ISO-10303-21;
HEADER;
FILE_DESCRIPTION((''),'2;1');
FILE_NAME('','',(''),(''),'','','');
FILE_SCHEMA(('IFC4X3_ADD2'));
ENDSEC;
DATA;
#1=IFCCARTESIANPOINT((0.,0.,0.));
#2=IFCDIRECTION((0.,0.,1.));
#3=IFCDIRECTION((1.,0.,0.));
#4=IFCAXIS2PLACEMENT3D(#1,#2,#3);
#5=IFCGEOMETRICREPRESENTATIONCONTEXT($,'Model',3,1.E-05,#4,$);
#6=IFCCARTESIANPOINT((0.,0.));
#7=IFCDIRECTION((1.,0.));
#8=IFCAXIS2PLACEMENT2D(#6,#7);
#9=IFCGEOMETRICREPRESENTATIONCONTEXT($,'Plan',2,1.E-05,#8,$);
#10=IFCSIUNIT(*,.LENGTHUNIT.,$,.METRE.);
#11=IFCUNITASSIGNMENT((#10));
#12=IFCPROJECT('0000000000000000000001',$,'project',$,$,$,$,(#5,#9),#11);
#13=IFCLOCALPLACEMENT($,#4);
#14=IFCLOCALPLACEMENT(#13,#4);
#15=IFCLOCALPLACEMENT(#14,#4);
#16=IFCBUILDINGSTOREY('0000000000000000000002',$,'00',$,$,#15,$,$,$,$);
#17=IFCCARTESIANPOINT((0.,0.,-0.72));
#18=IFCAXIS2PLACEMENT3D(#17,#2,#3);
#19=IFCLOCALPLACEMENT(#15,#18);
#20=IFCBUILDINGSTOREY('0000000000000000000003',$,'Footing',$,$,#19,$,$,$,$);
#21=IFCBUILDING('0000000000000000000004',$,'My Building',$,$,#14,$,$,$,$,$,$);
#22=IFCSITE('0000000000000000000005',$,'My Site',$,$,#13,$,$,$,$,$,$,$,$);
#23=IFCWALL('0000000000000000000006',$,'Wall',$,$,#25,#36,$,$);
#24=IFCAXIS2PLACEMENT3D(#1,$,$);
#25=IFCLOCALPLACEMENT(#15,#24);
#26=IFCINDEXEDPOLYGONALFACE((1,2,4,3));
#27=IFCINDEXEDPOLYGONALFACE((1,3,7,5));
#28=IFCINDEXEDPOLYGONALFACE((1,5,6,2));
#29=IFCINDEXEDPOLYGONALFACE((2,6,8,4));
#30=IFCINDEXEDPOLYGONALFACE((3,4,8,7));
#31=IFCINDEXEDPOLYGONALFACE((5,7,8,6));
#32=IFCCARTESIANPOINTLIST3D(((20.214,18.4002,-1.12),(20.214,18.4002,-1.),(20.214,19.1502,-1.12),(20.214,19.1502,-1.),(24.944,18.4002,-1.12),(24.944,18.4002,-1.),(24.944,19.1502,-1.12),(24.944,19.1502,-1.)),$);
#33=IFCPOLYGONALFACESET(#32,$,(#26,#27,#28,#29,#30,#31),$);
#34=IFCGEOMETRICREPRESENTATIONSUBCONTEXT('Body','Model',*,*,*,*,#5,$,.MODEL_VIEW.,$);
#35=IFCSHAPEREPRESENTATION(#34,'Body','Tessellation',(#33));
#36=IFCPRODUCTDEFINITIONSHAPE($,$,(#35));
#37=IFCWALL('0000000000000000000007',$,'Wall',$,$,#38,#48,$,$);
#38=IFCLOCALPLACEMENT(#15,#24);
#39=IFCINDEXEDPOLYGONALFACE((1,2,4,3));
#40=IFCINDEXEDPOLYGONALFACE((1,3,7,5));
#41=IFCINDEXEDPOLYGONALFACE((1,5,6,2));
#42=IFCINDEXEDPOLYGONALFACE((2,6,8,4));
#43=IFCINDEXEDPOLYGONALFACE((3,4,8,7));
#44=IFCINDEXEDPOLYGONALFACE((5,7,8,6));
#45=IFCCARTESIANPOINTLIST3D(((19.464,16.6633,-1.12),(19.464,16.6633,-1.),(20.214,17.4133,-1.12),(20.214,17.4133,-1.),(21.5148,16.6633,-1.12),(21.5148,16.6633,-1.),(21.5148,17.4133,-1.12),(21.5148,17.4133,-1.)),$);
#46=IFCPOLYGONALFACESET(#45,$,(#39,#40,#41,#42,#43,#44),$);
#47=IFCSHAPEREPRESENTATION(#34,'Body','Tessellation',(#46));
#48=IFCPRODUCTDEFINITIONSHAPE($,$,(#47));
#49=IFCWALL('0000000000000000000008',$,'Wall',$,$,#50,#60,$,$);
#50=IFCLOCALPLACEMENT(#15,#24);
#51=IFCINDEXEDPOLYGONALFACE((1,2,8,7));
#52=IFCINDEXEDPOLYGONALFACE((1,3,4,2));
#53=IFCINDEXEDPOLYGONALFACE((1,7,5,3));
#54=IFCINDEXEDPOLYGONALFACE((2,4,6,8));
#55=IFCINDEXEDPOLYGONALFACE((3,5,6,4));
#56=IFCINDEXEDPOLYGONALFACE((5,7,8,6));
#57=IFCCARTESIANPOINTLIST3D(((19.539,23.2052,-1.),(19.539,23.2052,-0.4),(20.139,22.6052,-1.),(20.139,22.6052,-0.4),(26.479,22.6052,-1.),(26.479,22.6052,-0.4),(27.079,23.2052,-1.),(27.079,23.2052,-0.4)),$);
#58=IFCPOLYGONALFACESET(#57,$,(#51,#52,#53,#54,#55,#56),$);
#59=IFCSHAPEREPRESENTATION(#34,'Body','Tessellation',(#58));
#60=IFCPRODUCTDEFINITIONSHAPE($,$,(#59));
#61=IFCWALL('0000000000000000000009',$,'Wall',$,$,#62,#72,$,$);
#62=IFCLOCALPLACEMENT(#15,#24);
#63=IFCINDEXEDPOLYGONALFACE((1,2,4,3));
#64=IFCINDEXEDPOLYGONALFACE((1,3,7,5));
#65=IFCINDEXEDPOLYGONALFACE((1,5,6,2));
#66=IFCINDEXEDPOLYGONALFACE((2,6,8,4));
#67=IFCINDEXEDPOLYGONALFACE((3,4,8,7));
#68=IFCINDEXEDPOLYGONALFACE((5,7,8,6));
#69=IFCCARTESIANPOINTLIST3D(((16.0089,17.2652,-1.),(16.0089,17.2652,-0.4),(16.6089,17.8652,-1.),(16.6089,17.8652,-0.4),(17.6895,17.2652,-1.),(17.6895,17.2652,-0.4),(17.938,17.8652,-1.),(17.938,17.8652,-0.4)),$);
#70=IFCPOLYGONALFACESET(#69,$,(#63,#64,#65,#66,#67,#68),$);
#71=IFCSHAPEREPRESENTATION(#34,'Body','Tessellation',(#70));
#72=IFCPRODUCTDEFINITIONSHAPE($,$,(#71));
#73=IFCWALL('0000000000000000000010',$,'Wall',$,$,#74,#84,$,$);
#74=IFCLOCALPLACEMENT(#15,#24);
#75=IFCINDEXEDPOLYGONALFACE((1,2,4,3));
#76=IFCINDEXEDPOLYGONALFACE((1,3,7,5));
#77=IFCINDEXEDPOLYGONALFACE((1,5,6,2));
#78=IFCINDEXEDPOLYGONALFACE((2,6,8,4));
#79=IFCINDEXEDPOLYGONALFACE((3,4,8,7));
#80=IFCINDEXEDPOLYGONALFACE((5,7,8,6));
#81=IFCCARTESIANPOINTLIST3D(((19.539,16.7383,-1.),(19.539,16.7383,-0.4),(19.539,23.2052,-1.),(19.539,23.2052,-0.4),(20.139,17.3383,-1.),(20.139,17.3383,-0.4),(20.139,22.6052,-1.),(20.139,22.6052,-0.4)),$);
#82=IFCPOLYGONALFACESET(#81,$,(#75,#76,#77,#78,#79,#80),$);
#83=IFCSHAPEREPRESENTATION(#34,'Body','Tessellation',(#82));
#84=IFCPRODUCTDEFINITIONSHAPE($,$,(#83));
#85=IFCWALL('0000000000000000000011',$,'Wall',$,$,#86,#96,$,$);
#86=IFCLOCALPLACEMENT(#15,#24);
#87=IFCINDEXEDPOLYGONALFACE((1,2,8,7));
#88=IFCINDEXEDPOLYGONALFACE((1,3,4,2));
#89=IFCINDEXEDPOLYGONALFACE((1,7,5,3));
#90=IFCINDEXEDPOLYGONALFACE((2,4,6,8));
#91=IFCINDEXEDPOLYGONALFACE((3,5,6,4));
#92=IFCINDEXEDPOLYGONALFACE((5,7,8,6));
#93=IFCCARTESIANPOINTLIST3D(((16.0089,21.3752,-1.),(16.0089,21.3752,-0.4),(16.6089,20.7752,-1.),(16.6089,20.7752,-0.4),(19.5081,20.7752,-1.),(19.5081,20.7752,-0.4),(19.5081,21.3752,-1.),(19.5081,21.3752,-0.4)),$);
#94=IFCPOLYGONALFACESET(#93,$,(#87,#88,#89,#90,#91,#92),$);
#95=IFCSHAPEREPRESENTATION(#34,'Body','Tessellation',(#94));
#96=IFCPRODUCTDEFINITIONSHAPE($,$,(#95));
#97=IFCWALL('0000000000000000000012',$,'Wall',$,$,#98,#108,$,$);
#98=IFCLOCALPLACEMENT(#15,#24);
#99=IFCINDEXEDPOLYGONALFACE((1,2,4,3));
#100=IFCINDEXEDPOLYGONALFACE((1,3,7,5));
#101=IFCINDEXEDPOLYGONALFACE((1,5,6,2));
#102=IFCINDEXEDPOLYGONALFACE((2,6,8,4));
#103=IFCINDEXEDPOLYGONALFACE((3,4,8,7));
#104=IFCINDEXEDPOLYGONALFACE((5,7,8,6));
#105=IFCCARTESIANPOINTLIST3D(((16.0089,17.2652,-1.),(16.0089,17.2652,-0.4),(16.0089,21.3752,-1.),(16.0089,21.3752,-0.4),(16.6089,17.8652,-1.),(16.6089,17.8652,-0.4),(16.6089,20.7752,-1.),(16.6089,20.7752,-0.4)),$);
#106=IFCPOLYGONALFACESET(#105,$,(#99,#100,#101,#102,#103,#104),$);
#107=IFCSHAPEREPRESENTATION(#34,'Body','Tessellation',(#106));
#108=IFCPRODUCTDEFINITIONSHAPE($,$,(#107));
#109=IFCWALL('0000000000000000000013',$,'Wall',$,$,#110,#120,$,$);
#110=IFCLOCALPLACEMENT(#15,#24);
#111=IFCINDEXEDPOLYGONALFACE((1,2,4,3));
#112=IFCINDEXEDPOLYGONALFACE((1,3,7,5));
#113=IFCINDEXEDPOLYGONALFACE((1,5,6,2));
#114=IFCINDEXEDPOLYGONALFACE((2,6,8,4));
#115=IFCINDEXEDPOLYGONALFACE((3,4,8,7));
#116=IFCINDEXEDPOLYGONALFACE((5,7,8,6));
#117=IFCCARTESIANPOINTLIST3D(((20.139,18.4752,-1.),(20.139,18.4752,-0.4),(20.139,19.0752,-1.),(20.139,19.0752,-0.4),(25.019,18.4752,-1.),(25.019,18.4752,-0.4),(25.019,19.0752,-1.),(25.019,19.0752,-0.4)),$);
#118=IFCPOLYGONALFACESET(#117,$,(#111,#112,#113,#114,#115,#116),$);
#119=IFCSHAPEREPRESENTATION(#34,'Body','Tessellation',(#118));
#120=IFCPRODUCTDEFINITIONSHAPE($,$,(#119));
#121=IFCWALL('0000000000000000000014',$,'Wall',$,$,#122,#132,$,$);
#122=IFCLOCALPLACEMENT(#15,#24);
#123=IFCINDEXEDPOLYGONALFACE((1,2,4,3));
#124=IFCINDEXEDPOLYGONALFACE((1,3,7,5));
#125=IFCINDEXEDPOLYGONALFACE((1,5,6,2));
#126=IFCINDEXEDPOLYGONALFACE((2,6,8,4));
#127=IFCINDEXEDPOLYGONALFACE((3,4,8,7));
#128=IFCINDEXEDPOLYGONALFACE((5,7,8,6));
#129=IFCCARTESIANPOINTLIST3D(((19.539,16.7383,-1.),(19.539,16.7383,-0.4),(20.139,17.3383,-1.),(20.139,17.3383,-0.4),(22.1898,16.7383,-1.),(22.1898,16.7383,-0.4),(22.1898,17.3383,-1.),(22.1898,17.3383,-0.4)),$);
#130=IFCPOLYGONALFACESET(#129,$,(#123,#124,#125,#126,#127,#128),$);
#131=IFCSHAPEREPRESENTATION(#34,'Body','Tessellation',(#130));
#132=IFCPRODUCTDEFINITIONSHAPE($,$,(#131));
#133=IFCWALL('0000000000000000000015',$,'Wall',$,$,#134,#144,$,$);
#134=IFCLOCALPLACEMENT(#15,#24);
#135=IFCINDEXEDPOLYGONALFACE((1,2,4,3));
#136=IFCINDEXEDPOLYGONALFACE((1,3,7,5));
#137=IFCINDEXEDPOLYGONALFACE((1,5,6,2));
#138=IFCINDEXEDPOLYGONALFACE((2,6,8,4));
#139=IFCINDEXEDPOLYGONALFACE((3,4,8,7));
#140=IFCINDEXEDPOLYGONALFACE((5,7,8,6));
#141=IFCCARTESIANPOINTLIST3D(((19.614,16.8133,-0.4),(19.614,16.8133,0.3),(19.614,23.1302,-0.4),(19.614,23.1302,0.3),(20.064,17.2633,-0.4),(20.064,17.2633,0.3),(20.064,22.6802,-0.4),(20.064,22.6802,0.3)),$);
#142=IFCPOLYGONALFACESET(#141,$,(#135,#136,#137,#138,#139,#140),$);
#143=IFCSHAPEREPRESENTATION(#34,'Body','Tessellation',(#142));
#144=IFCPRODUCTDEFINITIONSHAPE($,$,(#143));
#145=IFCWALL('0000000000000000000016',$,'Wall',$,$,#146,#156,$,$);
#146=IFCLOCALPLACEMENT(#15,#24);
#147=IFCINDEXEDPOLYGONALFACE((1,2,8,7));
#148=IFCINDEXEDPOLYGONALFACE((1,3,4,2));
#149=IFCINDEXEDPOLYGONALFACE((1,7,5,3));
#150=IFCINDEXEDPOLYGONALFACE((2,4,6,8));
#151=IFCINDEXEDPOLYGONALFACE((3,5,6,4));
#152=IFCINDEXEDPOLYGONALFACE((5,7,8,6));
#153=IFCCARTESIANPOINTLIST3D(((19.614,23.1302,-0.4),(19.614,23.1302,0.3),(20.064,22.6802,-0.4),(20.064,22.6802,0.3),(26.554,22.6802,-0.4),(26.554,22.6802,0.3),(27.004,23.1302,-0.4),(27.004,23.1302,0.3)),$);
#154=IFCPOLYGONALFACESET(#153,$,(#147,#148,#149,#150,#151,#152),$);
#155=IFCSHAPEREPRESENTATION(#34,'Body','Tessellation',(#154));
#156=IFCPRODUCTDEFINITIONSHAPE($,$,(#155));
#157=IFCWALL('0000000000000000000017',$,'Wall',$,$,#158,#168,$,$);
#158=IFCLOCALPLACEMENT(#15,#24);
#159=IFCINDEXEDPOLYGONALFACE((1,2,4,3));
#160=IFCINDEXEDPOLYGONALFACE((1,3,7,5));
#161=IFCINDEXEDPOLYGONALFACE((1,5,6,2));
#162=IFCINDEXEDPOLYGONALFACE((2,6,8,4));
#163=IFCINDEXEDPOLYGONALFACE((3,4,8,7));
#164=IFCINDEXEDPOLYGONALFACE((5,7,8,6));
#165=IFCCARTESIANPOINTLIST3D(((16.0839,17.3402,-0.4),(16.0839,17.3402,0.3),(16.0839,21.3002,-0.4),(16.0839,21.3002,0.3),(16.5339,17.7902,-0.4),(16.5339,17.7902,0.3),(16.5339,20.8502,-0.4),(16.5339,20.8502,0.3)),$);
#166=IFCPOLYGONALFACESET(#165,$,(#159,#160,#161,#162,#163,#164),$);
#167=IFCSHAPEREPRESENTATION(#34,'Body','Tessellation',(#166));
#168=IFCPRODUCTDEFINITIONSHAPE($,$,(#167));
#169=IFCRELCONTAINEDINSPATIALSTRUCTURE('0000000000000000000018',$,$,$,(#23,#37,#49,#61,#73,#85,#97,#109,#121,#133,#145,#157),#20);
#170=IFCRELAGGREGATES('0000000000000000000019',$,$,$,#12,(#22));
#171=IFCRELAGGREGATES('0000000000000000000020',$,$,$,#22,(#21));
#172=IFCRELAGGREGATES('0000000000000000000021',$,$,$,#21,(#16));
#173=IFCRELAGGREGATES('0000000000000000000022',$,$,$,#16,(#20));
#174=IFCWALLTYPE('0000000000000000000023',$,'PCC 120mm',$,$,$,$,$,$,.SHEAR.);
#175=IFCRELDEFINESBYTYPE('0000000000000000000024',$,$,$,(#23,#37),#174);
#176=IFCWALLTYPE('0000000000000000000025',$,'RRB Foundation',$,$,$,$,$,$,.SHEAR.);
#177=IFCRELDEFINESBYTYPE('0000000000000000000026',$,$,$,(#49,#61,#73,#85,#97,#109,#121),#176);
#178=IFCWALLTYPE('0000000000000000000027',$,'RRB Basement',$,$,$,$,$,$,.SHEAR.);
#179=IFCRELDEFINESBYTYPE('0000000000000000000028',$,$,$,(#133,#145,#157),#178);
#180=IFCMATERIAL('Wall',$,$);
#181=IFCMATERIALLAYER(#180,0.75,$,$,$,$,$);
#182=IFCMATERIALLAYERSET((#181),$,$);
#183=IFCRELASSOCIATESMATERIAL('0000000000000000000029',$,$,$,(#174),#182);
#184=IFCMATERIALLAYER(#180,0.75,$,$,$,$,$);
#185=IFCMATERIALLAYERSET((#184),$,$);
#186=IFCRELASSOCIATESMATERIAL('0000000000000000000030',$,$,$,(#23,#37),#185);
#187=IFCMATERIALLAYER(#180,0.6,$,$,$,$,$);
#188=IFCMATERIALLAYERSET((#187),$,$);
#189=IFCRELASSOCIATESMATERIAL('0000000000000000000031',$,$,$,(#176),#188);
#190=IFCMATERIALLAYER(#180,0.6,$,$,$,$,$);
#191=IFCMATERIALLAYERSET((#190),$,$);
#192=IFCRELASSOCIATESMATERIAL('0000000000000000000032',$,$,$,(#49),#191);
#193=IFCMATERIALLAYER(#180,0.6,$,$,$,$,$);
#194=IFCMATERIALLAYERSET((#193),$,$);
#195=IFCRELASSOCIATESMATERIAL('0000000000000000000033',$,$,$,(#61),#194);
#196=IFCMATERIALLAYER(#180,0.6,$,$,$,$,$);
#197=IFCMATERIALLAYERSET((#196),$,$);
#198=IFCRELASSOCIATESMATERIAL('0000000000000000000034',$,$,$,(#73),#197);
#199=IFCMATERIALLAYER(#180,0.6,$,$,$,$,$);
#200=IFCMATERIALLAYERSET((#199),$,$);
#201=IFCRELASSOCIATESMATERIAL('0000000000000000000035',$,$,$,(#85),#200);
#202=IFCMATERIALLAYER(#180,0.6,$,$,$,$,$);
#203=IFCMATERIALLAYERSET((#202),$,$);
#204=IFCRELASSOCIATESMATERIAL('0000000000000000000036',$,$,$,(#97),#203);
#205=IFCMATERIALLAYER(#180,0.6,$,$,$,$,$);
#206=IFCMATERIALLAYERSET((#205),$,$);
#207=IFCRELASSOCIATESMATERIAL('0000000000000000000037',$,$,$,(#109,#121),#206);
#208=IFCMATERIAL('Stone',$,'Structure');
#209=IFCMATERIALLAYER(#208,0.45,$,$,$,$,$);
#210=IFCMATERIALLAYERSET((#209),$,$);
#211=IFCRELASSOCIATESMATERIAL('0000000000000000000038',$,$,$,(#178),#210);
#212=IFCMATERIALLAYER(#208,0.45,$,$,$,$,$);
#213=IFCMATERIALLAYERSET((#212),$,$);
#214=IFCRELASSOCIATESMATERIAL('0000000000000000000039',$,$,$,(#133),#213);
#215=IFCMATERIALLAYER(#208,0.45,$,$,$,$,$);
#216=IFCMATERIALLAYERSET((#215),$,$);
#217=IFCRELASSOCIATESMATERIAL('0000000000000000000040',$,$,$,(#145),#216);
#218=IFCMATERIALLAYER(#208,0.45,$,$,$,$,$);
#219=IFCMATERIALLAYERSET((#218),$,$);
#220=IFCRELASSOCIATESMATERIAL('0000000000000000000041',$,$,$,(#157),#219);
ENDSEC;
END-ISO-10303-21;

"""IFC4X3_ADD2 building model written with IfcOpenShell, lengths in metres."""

from ifc_helpers import new_model, si_unit, frame, origin_with_axes, origin_2d_with_axis, place, context, subcontext, project, spatial, line, indexed_curve, outline, extrude, material, layer, layer_set, layer_usage, type_object, element, save


model = new_model("IFC4X3_ADD2")

# Units and contexts
model_context = context("Model", 3, precision=1e-05, world=origin_with_axes())
plan_context = context("Plan", 2, precision=1e-05, world=origin_2d_with_axis())
body_context = subcontext(model_context, "Body", "Model", "MODEL_VIEW")
ifc_project = project(units=[si_unit("LENGTHUNIT", "METRE")], contexts=[model_context, plan_context])

# Site, building, storeys
site_placement = place(None, origin_with_axes())
site = spatial("IfcSite", under=ifc_project, at=site_placement, Name="My Site")
building_placement = place(site_placement, origin_with_axes())
building = spatial("IfcBuilding", under=site, at=building_placement, Name="My Building")
storey_1_placement = place(building_placement, origin_with_axes())
storey_1 = spatial("IfcBuildingStorey", under=building, at=storey_1_placement, Name="00")
storey_2_placement = place(storey_1_placement, frame((0.0, 0.0, -0.72), z_axis=(0.0, 0.0, 1.0), x_axis=(1.0, 0.0, 0.0)))
storey_2 = spatial("IfcBuildingStorey", under=storey_1, at=storey_2_placement, Name="Footing")

# Shared definitions
ifc_material_1 = material(Name="Wall")

# Walls
ifc_layer_1 = layer(ifc_material_1, 0.75)
ifc_layer_set_1 = layer_set([ifc_layer_1])
wall_type_1 = type_object("IfcWallType", Name="PCC 120mm", PredefinedType="SHEAR", material=ifc_layer_set_1)
ifc_layer_2 = layer(ifc_material_1, 0.75)
ifc_layer_set_2 = layer_set([ifc_layer_2])
ifc_layer_usage_1 = layer_usage(ifc_layer_set_2, "AXIS2", "POSITIVE", 0.0)
wall_1_placement = place(storey_2_placement, frame((20.214, 18.4002, -0.4), z_axis=(0.0, 0.0, 1.0), x_axis=(1.0, 0.0, 0.0)))
element("IfcWall", 1, at=wall_1_placement, inside=storey_2, type_object=wall_type_1, material=ifc_layer_usage_1, Name="Wall", context=body_context, shape_type="SweptSolid", body=[
    extrude(outline(indexed_curve([(0.0, 0.0), (0.0, 0.75), (4.73, 0.75), (4.73, 0.0)], segments=[line(1, 2, 3, 4, 1)])), origin_with_axes(), (0.0, 0.0, 1.0), 0.12),
])
ifc_layer_usage_2 = layer_usage(ifc_layer_set_2, "AXIS2", "POSITIVE", 0.0)
wall_2_placement = place(storey_2_placement, frame((20.214, 16.6633, -0.4), z_axis=(0.0, 0.0, 1.0), x_axis=(1.0, 0.0, 0.0)))
element("IfcWall", 2, at=wall_2_placement, inside=storey_2, type_object=wall_type_1, material=ifc_layer_usage_2, Name="Wall", context=body_context, shape_type="SweptSolid", body=[
    extrude(outline(indexed_curve([(-0.75, 0.0), (0.0, 0.75), (1.3008, 0.75), (1.3008, 0.0)], segments=[line(1, 2, 3, 4, 1)])), origin_with_axes(), (0.0, 0.0, 1.0), 0.12),
])
ifc_layer_3 = layer(ifc_material_1, 0.6)
ifc_layer_set_3 = layer_set([ifc_layer_3])
ifc_layer_usage_3 = layer_usage(ifc_layer_set_3, "AXIS2", "POSITIVE", 0.0)
ifc_layer_4 = layer(ifc_material_1, 0.6)
ifc_layer_set_4 = layer_set([ifc_layer_4])
wall_type_2 = type_object("IfcWallType", Name="RRB Foundation", PredefinedType="SHEAR", material=ifc_layer_set_4)
wall_3_placement = place(storey_2_placement, frame((20.139, 22.6052, -0.28), z_axis=(0.0, 0.0, 1.0), x_axis=(1.0, 0.0, 0.0)))
element("IfcWall", 3, at=wall_3_placement, inside=storey_2, type_object=wall_type_2, material=ifc_layer_usage_3, Name="Wall", context=body_context, shape_type="SweptSolid", body=[
    extrude(outline(indexed_curve([(0.0, 0.0), (-0.6, 0.6), (6.94, 0.6), (6.34, 0.0)], segments=[line(1, 2, 3, 4, 1)])), origin_with_axes(), (0.0, 0.0, 1.0), 0.6),
])
ifc_layer_5 = layer(ifc_material_1, 0.6)
ifc_layer_set_5 = layer_set([ifc_layer_5])
ifc_layer_usage_4 = layer_usage(ifc_layer_set_5, "AXIS2", "POSITIVE", 0.0)
wall_4_placement = place(storey_2_placement, frame((16.6089, 17.2652, -0.28), z_axis=(0.0, 0.0, 1.0), x_axis=(1.0, 0.0, 0.0)))
element("IfcWall", 4, at=wall_4_placement, inside=storey_2, type_object=wall_type_2, material=ifc_layer_usage_4, Name="Wall", context=body_context, shape_type="SweptSolid", body=[
    extrude(outline(indexed_curve([(-0.6, 0.0), (0.0, 0.6), (1.3291, 0.6), (1.0806, 0.0)], segments=[line(1, 2, 3, 4, 1)])), origin_with_axes(), (0.0, 0.0, 1.0), 0.6),
])
ifc_layer_6 = layer(ifc_material_1, 0.6)
ifc_layer_set_6 = layer_set([ifc_layer_6])
ifc_layer_usage_5 = layer_usage(ifc_layer_set_6, "AXIS2", "POSITIVE", 0.0)
wall_5_placement = place(storey_2_placement, frame((20.139, 16.7383, -0.28), z_axis=(0.0, 0.0, 1.0), x_axis=(0.0, 1.0, 0.0)))
element("IfcWall", 5, at=wall_5_placement, inside=storey_2, type_object=wall_type_2, material=ifc_layer_usage_5, Name="Wall", context=body_context, shape_type="SweptSolid", body=[
    extrude(outline(indexed_curve([(0.6, 0.0), (0.0, 0.6), (6.4669, 0.6), (5.8669, 0.0)], segments=[line(1, 2, 3, 4, 1)])), origin_with_axes(), (0.0, 0.0, 1.0), 0.6),
])
ifc_layer_7 = layer(ifc_material_1, 0.6)
ifc_layer_set_7 = layer_set([ifc_layer_7])
ifc_layer_usage_6 = layer_usage(ifc_layer_set_7, "AXIS2", "POSITIVE", 0.0)
wall_6_placement = place(storey_2_placement, frame((16.6089, 20.7752, -0.28), z_axis=(0.0, 0.0, 1.0), x_axis=(1.0, 0.0, 0.0)))
element("IfcWall", 6, at=wall_6_placement, inside=storey_2, type_object=wall_type_2, material=ifc_layer_usage_6, Name="Wall", context=body_context, shape_type="SweptSolid", body=[
    extrude(outline(indexed_curve([(0.0, 0.0), (-0.6, 0.6), (2.8992, 0.6), (2.8992, 0.0)], segments=[line(1, 2, 3, 4, 1)])), origin_with_axes(), (0.0, 0.0, 1.0), 0.6),
])
ifc_layer_8 = layer(ifc_material_1, 0.6)
ifc_layer_set_8 = layer_set([ifc_layer_8])
ifc_layer_usage_7 = layer_usage(ifc_layer_set_8, "AXIS2", "POSITIVE", 0.0)
wall_7_placement = place(storey_2_placement, frame((16.6089, 17.2652, -0.28), z_axis=(0.0, 0.0, 1.0), x_axis=(0.0, 1.0, 0.0)))
element("IfcWall", 7, at=wall_7_placement, inside=storey_2, type_object=wall_type_2, material=ifc_layer_usage_7, Name="Wall", context=body_context, shape_type="SweptSolid", body=[
    extrude(outline(indexed_curve([(0.6, 0.0), (0.0, 0.6), (4.11, 0.6), (3.51, 0.0)], segments=[line(1, 2, 3, 4, 1)])), origin_with_axes(), (0.0, 0.0, 1.0), 0.6),
])
ifc_layer_9 = layer(ifc_material_1, 0.6)
ifc_layer_set_9 = layer_set([ifc_layer_9])
ifc_layer_usage_8 = layer_usage(ifc_layer_set_9, "AXIS2", "POSITIVE", 0.0)
wall_8_placement = place(storey_2_placement, frame((20.139, 18.4752, -0.28), z_axis=(0.0, 0.0, 1.0), x_axis=(1.0, 0.0, 0.0)))
element("IfcWall", 8, at=wall_8_placement, inside=storey_2, type_object=wall_type_2, material=ifc_layer_usage_8, Name="Wall", context=body_context, shape_type="SweptSolid", body=[
    extrude(outline(indexed_curve([(0.0, 0.0), (0.0, 0.6), (4.88, 0.6), (4.88, 0.0)], segments=[line(1, 2, 3, 4, 1)])), origin_with_axes(), (0.0, 0.0, 1.0), 0.6),
])
ifc_layer_usage_9 = layer_usage(ifc_layer_set_9, "AXIS2", "POSITIVE", 0.0)
wall_9_placement = place(storey_2_placement, frame((20.139, 16.7383, -0.28), z_axis=(0.0, 0.0, 1.0), x_axis=(1.0, 0.0, 0.0)))
element("IfcWall", 9, at=wall_9_placement, inside=storey_2, type_object=wall_type_2, material=ifc_layer_usage_9, Name="Wall", context=body_context, shape_type="SweptSolid", body=[
    extrude(outline(indexed_curve([(-0.6, 0.0), (0.0, 0.6), (2.0508, 0.6), (2.0508, 0.0)], segments=[line(1, 2, 3, 4, 1)])), origin_with_axes(), (0.0, 0.0, 1.0), 0.6),
])
ifc_material_2 = material(Name="Stone", Category="Structure")
ifc_layer_10 = layer(ifc_material_2, 0.45)
ifc_layer_set_10 = layer_set([ifc_layer_10])
ifc_layer_usage_10 = layer_usage(ifc_layer_set_10, "AXIS2", "POSITIVE", 0.0)
ifc_layer_11 = layer(ifc_material_2, 0.45)
ifc_layer_set_11 = layer_set([ifc_layer_11])
wall_type_3 = type_object("IfcWallType", Name="RRB Basement", PredefinedType="SHEAR", material=ifc_layer_set_11)
wall_10_placement = place(storey_2_placement, frame((20.064, 16.8133, 0.32), z_axis=(0.0, 0.0, 1.0), x_axis=(0.0, 1.0, 0.0)))
element("IfcWall", 10, at=wall_10_placement, inside=storey_2, type_object=wall_type_3, material=ifc_layer_usage_10, Name="Wall", context=body_context, shape_type="SweptSolid", body=[
    extrude(outline(indexed_curve([(0.45, 0.0), (0.0, 0.45), (6.3169, 0.45), (5.8669, 0.0)], segments=[line(1, 2, 3, 4, 1)])), origin_with_axes(), (0.0, 0.0, 1.0), 0.7),
])
ifc_layer_12 = layer(ifc_material_2, 0.45)
ifc_layer_set_12 = layer_set([ifc_layer_12])
ifc_layer_usage_11 = layer_usage(ifc_layer_set_12, "AXIS2", "POSITIVE", 0.0)
wall_11_placement = place(storey_2_placement, frame((20.064, 22.6802, 0.32), z_axis=(0.0, 0.0, 1.0), x_axis=(1.0, 0.0, 0.0)))
element("IfcWall", 11, at=wall_11_placement, inside=storey_2, type_object=wall_type_3, material=ifc_layer_usage_11, Name="Wall", context=body_context, shape_type="SweptSolid", body=[
    extrude(outline(indexed_curve([(0.0, 0.0), (-0.45, 0.45), (6.94, 0.45), (6.49, 0.0)], segments=[line(1, 2, 3, 4, 1)])), origin_with_axes(), (0.0, 0.0, 1.0), 0.7),
])
ifc_layer_13 = layer(ifc_material_2, 0.45)
ifc_layer_set_13 = layer_set([ifc_layer_13])
ifc_layer_usage_12 = layer_usage(ifc_layer_set_13, "AXIS2", "POSITIVE", 0.0)
wall_12_placement = place(storey_2_placement, frame((16.5339, 17.3402, 0.32), z_axis=(0.0, 0.0, 1.0), x_axis=(0.0, 1.0, 0.0)))
element("IfcWall", 12, at=wall_12_placement, inside=storey_2, type_object=wall_type_3, material=ifc_layer_usage_12, Name="Wall", context=body_context, shape_type="SweptSolid", body=[
    extrude(outline(indexed_curve([(0.45, 0.0), (0.0, 0.45), (3.96, 0.45), (3.51, 0.0)], segments=[line(1, 2, 3, 4, 1)])), origin_with_axes(), (0.0, 0.0, 1.0), 0.7),
])

save(model, "model.ifc")
